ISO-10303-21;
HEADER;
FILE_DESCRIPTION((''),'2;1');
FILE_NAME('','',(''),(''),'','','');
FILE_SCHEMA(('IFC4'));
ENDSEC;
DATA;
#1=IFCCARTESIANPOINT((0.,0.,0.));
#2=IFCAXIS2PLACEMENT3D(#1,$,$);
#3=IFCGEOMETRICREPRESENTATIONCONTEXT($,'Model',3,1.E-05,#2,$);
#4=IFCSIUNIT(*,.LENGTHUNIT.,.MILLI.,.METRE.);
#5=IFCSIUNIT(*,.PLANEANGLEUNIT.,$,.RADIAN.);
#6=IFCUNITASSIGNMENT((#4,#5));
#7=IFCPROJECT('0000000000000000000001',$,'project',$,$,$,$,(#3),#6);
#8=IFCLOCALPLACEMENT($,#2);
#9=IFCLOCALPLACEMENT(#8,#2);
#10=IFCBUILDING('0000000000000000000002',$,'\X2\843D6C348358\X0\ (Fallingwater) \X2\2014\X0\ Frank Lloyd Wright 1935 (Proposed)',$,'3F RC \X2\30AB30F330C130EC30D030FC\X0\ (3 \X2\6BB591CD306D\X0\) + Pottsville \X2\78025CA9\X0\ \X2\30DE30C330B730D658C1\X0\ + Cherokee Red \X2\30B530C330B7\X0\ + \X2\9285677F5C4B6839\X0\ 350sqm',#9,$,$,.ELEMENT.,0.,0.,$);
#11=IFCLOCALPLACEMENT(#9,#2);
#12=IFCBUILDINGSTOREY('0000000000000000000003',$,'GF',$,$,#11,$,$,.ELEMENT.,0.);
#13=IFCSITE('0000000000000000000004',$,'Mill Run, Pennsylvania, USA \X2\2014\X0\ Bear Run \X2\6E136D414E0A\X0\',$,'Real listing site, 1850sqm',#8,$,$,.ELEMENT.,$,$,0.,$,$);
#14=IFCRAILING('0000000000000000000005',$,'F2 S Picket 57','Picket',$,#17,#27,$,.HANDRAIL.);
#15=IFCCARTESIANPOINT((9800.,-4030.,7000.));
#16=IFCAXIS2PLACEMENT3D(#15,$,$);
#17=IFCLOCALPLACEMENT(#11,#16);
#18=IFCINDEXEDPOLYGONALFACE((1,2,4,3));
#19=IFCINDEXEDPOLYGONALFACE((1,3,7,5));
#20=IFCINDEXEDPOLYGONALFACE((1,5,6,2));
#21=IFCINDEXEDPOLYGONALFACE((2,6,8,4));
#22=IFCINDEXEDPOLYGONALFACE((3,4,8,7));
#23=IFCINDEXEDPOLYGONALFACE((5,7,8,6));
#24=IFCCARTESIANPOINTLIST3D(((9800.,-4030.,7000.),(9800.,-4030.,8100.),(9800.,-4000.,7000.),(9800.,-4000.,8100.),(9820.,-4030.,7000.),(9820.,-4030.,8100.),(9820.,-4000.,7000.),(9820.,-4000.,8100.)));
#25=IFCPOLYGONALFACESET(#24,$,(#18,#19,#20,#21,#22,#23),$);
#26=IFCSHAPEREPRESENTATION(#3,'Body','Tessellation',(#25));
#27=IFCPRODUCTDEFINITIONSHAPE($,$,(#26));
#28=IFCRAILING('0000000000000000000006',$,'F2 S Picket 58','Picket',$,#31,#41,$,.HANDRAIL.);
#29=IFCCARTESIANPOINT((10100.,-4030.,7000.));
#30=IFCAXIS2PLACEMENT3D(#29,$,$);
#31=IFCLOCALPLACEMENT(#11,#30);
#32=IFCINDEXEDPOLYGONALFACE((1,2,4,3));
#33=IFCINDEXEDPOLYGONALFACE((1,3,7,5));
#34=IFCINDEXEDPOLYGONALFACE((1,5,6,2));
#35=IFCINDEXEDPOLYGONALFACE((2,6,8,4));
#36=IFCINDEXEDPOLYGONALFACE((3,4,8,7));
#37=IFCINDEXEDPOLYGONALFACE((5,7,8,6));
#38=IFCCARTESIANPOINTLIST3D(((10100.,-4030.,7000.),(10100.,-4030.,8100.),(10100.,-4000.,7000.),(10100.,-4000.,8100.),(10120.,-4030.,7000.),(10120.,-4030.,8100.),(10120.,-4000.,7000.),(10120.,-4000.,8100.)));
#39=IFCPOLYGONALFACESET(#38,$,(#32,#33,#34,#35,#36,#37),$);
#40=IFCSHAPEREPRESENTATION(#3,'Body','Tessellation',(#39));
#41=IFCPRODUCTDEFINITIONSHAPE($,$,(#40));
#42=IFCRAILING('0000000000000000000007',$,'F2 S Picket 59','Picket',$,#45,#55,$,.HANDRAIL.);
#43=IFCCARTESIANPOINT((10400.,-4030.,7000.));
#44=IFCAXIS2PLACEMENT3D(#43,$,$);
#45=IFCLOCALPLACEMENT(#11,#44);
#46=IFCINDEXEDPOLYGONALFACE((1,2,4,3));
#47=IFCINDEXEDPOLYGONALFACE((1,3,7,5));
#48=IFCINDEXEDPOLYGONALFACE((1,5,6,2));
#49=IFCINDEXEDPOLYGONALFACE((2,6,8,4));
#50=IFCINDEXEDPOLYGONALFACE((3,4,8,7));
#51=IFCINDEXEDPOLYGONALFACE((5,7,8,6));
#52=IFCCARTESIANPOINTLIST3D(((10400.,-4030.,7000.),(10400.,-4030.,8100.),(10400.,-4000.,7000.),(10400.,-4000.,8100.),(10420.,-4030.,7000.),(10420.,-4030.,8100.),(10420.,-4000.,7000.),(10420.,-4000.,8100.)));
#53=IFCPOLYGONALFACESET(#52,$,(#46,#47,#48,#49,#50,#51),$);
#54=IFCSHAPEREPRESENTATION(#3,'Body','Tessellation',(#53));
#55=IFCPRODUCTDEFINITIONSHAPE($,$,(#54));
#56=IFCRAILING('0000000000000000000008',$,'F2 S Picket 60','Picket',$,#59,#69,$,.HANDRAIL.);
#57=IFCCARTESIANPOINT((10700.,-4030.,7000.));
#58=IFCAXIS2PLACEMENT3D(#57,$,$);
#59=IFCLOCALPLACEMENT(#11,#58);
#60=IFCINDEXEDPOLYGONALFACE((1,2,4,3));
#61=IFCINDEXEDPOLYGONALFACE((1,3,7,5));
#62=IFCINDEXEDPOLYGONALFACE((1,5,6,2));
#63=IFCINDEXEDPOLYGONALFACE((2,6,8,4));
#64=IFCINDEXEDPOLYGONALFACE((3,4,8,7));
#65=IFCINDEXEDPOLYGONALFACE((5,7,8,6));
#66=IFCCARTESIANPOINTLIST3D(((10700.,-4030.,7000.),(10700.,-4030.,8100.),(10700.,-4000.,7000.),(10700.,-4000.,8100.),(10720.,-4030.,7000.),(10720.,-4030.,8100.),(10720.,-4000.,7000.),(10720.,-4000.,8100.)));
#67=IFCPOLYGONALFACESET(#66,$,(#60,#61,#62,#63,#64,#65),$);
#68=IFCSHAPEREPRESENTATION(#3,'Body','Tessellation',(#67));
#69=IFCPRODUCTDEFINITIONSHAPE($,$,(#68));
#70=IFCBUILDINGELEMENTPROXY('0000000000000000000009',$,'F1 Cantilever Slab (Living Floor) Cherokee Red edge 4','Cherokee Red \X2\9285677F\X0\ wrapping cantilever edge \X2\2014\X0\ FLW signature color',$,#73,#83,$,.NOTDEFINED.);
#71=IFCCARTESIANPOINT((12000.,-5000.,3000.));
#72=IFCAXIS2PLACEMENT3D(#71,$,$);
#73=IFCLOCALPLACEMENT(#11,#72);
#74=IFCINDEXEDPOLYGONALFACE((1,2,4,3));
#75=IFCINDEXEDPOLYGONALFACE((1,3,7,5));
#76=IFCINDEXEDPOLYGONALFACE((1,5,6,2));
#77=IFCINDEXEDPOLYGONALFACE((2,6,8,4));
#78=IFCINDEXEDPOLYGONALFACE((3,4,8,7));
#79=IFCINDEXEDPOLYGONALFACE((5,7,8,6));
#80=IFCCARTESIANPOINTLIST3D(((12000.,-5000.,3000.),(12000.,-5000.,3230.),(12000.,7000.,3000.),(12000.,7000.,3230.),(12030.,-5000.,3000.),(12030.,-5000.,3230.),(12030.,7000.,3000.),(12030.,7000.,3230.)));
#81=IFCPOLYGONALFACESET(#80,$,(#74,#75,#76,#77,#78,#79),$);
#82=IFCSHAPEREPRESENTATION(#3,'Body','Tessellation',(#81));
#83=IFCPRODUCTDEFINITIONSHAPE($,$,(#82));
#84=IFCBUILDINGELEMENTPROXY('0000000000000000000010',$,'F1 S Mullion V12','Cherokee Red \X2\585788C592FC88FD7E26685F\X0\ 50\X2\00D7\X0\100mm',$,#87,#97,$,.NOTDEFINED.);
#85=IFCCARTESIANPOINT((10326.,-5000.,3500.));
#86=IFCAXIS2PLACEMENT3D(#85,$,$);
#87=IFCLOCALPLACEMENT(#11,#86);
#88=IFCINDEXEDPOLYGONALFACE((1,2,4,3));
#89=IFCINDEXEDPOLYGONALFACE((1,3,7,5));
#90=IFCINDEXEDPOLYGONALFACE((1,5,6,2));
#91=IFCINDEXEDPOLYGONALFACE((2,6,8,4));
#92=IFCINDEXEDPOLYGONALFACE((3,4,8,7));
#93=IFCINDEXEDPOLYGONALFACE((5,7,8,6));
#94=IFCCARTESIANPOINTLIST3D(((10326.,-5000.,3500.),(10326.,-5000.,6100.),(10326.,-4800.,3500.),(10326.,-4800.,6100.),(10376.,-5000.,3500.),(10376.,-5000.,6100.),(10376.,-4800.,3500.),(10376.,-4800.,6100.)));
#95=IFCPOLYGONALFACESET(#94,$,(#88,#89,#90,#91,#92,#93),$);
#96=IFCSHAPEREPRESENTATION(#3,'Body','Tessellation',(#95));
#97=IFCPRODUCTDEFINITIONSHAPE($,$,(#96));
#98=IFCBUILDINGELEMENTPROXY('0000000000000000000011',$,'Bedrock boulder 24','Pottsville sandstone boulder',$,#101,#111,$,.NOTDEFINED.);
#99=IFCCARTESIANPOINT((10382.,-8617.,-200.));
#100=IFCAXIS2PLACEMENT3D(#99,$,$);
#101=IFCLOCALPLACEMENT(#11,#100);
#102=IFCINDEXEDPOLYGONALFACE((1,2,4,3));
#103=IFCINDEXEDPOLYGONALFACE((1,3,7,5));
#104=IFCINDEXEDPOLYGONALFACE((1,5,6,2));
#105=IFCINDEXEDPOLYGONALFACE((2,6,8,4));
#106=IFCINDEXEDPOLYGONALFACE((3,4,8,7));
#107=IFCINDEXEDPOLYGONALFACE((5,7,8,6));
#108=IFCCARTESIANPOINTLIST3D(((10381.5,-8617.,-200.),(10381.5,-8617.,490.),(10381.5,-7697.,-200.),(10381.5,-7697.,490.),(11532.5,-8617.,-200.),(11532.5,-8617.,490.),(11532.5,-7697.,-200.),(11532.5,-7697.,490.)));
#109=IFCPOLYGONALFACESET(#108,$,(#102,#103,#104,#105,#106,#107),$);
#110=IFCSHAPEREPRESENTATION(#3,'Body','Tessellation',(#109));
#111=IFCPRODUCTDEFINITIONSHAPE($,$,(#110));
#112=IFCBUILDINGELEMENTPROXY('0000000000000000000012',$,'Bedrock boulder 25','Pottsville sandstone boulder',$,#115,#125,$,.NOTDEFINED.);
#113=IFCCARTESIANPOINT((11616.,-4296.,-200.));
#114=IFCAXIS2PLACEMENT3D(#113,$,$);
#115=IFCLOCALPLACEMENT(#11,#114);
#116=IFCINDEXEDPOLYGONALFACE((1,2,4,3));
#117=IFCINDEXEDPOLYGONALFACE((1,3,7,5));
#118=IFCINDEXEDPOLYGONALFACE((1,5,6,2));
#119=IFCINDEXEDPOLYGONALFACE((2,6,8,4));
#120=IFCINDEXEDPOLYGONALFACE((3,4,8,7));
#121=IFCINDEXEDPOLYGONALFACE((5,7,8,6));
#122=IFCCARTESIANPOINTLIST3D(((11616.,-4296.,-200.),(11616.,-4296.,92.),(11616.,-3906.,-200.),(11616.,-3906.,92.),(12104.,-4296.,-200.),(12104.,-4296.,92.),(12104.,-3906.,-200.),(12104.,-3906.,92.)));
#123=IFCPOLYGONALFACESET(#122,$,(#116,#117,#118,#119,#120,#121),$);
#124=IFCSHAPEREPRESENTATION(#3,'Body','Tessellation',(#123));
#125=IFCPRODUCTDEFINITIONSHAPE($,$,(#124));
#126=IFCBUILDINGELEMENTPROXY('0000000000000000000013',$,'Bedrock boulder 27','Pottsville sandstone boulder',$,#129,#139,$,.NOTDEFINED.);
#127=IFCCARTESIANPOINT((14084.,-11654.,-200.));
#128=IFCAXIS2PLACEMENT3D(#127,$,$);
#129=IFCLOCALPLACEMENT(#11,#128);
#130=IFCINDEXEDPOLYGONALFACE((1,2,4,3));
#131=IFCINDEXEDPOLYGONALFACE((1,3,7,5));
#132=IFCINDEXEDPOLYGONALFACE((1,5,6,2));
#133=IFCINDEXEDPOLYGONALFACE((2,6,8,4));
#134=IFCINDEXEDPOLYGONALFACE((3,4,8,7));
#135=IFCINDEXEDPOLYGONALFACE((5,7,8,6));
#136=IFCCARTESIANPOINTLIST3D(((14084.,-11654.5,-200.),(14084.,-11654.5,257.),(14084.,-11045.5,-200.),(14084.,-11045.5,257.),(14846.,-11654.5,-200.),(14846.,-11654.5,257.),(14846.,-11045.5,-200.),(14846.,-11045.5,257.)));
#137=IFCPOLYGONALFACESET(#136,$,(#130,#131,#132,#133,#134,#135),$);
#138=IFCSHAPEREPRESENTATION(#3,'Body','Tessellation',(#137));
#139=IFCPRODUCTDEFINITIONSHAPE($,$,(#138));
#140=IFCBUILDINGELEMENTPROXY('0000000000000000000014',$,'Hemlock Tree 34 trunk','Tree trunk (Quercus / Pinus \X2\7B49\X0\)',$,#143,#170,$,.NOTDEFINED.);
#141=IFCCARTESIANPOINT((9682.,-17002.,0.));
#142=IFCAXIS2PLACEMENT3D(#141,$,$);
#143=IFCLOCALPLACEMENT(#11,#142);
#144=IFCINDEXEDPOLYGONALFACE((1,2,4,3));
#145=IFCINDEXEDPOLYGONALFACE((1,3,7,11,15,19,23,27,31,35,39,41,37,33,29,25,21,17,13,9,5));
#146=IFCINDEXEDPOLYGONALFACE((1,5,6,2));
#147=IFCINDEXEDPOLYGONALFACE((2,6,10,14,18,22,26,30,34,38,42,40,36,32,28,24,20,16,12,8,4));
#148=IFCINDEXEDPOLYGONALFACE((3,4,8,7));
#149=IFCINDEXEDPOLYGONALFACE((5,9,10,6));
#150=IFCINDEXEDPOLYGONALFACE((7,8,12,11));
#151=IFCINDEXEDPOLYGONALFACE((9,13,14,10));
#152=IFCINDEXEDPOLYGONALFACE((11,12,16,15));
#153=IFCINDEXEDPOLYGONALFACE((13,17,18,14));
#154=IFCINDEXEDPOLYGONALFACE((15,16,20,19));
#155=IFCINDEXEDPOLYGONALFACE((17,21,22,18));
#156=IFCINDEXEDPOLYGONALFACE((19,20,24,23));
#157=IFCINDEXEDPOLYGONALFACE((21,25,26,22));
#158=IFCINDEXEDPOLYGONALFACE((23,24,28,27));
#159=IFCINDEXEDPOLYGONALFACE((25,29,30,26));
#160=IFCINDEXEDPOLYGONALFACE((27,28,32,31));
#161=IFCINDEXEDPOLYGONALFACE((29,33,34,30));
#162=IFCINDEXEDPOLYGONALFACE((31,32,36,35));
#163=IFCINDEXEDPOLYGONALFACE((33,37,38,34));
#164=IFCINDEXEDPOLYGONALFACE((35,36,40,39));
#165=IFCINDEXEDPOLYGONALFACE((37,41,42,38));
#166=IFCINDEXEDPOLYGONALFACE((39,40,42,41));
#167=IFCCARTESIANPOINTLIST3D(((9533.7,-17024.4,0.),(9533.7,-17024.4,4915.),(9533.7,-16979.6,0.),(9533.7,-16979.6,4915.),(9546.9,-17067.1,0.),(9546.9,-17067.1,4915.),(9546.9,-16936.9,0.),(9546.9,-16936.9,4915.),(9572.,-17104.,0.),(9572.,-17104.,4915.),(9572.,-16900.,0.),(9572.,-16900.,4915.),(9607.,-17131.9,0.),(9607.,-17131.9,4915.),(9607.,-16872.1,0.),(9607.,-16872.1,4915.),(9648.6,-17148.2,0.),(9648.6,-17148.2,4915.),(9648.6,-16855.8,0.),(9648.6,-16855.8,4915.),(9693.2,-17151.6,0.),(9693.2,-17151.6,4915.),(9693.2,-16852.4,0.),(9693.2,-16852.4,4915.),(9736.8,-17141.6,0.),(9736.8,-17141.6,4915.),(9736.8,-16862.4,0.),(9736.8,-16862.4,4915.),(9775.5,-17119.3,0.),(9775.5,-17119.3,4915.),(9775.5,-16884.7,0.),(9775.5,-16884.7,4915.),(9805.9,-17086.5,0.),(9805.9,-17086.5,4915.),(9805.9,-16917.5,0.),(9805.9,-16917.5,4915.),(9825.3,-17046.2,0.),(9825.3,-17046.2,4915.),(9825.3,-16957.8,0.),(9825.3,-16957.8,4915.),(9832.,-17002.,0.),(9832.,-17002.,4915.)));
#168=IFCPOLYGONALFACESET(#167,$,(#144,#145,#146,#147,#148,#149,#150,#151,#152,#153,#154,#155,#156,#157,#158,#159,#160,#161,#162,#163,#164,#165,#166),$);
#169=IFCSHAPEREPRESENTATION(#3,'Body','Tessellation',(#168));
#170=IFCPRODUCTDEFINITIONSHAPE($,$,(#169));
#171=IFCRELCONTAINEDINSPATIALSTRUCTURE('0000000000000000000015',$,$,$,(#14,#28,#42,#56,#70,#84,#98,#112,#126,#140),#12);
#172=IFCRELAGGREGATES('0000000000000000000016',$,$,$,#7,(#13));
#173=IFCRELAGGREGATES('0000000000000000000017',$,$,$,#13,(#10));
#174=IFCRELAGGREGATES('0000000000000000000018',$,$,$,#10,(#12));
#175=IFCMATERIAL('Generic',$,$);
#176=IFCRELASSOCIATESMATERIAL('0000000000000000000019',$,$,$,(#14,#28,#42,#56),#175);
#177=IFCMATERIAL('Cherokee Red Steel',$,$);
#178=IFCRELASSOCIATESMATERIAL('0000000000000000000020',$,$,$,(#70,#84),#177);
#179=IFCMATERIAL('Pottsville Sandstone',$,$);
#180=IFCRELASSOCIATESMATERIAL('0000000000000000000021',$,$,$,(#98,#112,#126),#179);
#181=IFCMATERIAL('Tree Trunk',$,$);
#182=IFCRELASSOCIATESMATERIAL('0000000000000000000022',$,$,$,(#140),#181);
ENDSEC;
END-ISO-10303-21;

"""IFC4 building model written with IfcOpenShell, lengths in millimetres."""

from ifc_helpers import new_model, si_unit, frame, frame_2d, origin, origin_2d, place, context, project, spatial, rectangle, circle, extrude, material, element, save


model = new_model("IFC4")

# Units and contexts
model_context = context("Model", 3, precision=1e-05, world=origin())
ifc_project = project(units=[si_unit("LENGTHUNIT", "METRE", prefix="MILLI"), si_unit("PLANEANGLEUNIT", "RADIAN")], contexts=[model_context])

# Site, building, storey
site_placement = place(None, origin())
site = spatial("IfcSite", under=ifc_project, at=site_placement, Name="Mill Run, Pennsylvania, USA — Bear Run 渓流上", ObjectType="Real listing site, 1850sqm", CompositionType="ELEMENT", RefElevation=0.0)
building_placement = place(site_placement, origin())
building = spatial("IfcBuilding", under=site, at=building_placement, Name="落水荘 (Fallingwater) — Frank Lloyd Wright 1935 (Proposed)", ObjectType="3F RC カンチレバー (3 段重ね) + Pottsville 砂岩 マッシブ壁 + Cherokee Red サッシ + 銅板屋根 350sqm", CompositionType="ELEMENT", ElevationOfRefHeight=0.0, ElevationOfTerrain=0.0)
storey_placement = place(building_placement, origin())
storey = spatial("IfcBuildingStorey", under=building, at=storey_placement, Name="GF", CompositionType="ELEMENT", Elevation=0.0)

# Shared definitions
ifc_material_1 = material(Name="Cherokee Red Steel")

# Railings
ifc_material_2 = material(Name="Generic")
railing_1_placement = place(storey_placement, frame((9800.0, -4030.0, 7000.0)))
element("IfcRailing", 1, at=railing_1_placement, inside=storey, material=ifc_material_2, Name="F2 S Picket 57", Description="Picket", PredefinedType="HANDRAIL", context=model_context, shape_type="SweptSolid", body=[
    extrude(rectangle(XDim=20.0, YDim=30.0, at=frame_2d((10.0, 15.0))), frame((9800.0, -4030.0, 7000.0)), (0.0, 0.0, 1.0), 1100.0),
])
railing_2_placement = place(storey_placement, frame((10100.0, -4030.0, 7000.0)))
element("IfcRailing", 2, at=railing_2_placement, inside=storey, material=ifc_material_2, Name="F2 S Picket 58", Description="Picket", PredefinedType="HANDRAIL", context=model_context, shape_type="SweptSolid", body=[
    extrude(rectangle(XDim=20.0, YDim=30.0, at=frame_2d((10.0, 15.0))), frame((10100.0, -4030.0, 7000.0)), (0.0, 0.0, 1.0), 1100.0),
])
railing_3_placement = place(storey_placement, frame((10400.0, -4030.0, 7000.0)))
element("IfcRailing", 3, at=railing_3_placement, inside=storey, material=ifc_material_2, Name="F2 S Picket 59", Description="Picket", PredefinedType="HANDRAIL", context=model_context, shape_type="SweptSolid", body=[
    extrude(rectangle(XDim=20.0, YDim=30.0, at=frame_2d((10.0, 15.0))), frame((10400.0, -4030.0, 7000.0)), (0.0, 0.0, 1.0), 1100.0),
])
railing_4_placement = place(storey_placement, frame((10700.0, -4030.0, 7000.0)))
element("IfcRailing", 4, at=railing_4_placement, inside=storey, material=ifc_material_2, Name="F2 S Picket 60", Description="Picket", PredefinedType="HANDRAIL", context=model_context, shape_type="SweptSolid", body=[
    extrude(rectangle(XDim=20.0, YDim=30.0, at=frame_2d((10.0, 15.0))), frame((10700.0, -4030.0, 7000.0)), (0.0, 0.0, 1.0), 1100.0),
])

# Building element proxies
proxy_1_placement = place(storey_placement, frame((12000.0, -5000.0, 3000.0)))
element("IfcBuildingElementProxy", 5, at=proxy_1_placement, inside=storey, material=ifc_material_1, Name="F1 Cantilever Slab (Living Floor) Cherokee Red edge 4", Description="Cherokee Red 銅板 wrapping cantilever edge — FLW signature color", PredefinedType="NOTDEFINED", context=model_context, shape_type="SweptSolid", body=[
    extrude(rectangle(XDim=30.0, YDim=12000.0, at=frame_2d((15.0, 6000.0))), frame((12000.0, -5000.0, 3000.0)), (0.0, 0.0, 1.0), 230.0),
])
proxy_2_placement = place(storey_placement, frame((10326.0, -5000.0, 3500.0)))
element("IfcBuildingElementProxy", 6, at=proxy_2_placement, inside=storey, material=ifc_material_1, Name="F1 S Mullion V12", Description="Cherokee Red 塗装鋼製縦桟 50×100mm", PredefinedType="NOTDEFINED", context=model_context, shape_type="SweptSolid", body=[
    extrude(rectangle(XDim=50.0, YDim=200.0, at=frame_2d((25.0, 100.0))), frame((10326.0, -5000.0, 3500.0)), (0.0, 0.0, 1.0), 2600.0),
])
ifc_material_3 = material(Name="Pottsville Sandstone")
proxy_3_placement = place(storey_placement, frame((10382.0, -8617.0, -200.0)))
element("IfcBuildingElementProxy", 7, at=proxy_3_placement, inside=storey, material=ifc_material_3, Name="Bedrock boulder 24", Description="Pottsville sandstone boulder", PredefinedType="NOTDEFINED", context=model_context, shape_type="SweptSolid", body=[
    extrude(rectangle(XDim=1151.0, YDim=920.0, at=frame_2d((575.0, 460.0))), frame((10382.0, -8617.0, -200.0)), (0.0, 0.0, 1.0), 690.0),
])
proxy_4_placement = place(storey_placement, frame((11616.0, -4296.0, -200.0)))
element("IfcBuildingElementProxy", 8, at=proxy_4_placement, inside=storey, material=ifc_material_3, Name="Bedrock boulder 25", Description="Pottsville sandstone boulder", PredefinedType="NOTDEFINED", context=model_context, shape_type="SweptSolid", body=[
    extrude(rectangle(XDim=488.0, YDim=390.0, at=frame_2d((244.0, 195.0))), frame((11616.0, -4296.0, -200.0)), (0.0, 0.0, 1.0), 292.0),
])
proxy_5_placement = place(storey_placement, frame((14084.0, -11654.0, -200.0)))
element("IfcBuildingElementProxy", 9, at=proxy_5_placement, inside=storey, material=ifc_material_3, Name="Bedrock boulder 27", Description="Pottsville sandstone boulder", PredefinedType="NOTDEFINED", context=model_context, shape_type="SweptSolid", body=[
    extrude(rectangle(XDim=762.0, YDim=609.0, at=frame_2d((381.0, 304.0))), frame((14084.0, -11654.0, -200.0)), (0.0, 0.0, 1.0), 457.0),
])
ifc_material_4 = material(Name="Tree Trunk")
proxy_6_placement = place(storey_placement, frame((9682.0, -17002.0, 0.0)))
element("IfcBuildingElementProxy", 10, at=proxy_6_placement, inside=storey, material=ifc_material_4, Name="Hemlock Tree 34 trunk", Description="Tree trunk (Quercus / Pinus 等)", PredefinedType="NOTDEFINED", context=model_context, shape_type="SweptSolid", body=[
    extrude(circle(Radius=150.0, at=origin_2d()), frame((9682.0, -17002.0, 0.0)), (0.0, 0.0, 1.0), 4915.0),
])

save(model, "model.ifc")
